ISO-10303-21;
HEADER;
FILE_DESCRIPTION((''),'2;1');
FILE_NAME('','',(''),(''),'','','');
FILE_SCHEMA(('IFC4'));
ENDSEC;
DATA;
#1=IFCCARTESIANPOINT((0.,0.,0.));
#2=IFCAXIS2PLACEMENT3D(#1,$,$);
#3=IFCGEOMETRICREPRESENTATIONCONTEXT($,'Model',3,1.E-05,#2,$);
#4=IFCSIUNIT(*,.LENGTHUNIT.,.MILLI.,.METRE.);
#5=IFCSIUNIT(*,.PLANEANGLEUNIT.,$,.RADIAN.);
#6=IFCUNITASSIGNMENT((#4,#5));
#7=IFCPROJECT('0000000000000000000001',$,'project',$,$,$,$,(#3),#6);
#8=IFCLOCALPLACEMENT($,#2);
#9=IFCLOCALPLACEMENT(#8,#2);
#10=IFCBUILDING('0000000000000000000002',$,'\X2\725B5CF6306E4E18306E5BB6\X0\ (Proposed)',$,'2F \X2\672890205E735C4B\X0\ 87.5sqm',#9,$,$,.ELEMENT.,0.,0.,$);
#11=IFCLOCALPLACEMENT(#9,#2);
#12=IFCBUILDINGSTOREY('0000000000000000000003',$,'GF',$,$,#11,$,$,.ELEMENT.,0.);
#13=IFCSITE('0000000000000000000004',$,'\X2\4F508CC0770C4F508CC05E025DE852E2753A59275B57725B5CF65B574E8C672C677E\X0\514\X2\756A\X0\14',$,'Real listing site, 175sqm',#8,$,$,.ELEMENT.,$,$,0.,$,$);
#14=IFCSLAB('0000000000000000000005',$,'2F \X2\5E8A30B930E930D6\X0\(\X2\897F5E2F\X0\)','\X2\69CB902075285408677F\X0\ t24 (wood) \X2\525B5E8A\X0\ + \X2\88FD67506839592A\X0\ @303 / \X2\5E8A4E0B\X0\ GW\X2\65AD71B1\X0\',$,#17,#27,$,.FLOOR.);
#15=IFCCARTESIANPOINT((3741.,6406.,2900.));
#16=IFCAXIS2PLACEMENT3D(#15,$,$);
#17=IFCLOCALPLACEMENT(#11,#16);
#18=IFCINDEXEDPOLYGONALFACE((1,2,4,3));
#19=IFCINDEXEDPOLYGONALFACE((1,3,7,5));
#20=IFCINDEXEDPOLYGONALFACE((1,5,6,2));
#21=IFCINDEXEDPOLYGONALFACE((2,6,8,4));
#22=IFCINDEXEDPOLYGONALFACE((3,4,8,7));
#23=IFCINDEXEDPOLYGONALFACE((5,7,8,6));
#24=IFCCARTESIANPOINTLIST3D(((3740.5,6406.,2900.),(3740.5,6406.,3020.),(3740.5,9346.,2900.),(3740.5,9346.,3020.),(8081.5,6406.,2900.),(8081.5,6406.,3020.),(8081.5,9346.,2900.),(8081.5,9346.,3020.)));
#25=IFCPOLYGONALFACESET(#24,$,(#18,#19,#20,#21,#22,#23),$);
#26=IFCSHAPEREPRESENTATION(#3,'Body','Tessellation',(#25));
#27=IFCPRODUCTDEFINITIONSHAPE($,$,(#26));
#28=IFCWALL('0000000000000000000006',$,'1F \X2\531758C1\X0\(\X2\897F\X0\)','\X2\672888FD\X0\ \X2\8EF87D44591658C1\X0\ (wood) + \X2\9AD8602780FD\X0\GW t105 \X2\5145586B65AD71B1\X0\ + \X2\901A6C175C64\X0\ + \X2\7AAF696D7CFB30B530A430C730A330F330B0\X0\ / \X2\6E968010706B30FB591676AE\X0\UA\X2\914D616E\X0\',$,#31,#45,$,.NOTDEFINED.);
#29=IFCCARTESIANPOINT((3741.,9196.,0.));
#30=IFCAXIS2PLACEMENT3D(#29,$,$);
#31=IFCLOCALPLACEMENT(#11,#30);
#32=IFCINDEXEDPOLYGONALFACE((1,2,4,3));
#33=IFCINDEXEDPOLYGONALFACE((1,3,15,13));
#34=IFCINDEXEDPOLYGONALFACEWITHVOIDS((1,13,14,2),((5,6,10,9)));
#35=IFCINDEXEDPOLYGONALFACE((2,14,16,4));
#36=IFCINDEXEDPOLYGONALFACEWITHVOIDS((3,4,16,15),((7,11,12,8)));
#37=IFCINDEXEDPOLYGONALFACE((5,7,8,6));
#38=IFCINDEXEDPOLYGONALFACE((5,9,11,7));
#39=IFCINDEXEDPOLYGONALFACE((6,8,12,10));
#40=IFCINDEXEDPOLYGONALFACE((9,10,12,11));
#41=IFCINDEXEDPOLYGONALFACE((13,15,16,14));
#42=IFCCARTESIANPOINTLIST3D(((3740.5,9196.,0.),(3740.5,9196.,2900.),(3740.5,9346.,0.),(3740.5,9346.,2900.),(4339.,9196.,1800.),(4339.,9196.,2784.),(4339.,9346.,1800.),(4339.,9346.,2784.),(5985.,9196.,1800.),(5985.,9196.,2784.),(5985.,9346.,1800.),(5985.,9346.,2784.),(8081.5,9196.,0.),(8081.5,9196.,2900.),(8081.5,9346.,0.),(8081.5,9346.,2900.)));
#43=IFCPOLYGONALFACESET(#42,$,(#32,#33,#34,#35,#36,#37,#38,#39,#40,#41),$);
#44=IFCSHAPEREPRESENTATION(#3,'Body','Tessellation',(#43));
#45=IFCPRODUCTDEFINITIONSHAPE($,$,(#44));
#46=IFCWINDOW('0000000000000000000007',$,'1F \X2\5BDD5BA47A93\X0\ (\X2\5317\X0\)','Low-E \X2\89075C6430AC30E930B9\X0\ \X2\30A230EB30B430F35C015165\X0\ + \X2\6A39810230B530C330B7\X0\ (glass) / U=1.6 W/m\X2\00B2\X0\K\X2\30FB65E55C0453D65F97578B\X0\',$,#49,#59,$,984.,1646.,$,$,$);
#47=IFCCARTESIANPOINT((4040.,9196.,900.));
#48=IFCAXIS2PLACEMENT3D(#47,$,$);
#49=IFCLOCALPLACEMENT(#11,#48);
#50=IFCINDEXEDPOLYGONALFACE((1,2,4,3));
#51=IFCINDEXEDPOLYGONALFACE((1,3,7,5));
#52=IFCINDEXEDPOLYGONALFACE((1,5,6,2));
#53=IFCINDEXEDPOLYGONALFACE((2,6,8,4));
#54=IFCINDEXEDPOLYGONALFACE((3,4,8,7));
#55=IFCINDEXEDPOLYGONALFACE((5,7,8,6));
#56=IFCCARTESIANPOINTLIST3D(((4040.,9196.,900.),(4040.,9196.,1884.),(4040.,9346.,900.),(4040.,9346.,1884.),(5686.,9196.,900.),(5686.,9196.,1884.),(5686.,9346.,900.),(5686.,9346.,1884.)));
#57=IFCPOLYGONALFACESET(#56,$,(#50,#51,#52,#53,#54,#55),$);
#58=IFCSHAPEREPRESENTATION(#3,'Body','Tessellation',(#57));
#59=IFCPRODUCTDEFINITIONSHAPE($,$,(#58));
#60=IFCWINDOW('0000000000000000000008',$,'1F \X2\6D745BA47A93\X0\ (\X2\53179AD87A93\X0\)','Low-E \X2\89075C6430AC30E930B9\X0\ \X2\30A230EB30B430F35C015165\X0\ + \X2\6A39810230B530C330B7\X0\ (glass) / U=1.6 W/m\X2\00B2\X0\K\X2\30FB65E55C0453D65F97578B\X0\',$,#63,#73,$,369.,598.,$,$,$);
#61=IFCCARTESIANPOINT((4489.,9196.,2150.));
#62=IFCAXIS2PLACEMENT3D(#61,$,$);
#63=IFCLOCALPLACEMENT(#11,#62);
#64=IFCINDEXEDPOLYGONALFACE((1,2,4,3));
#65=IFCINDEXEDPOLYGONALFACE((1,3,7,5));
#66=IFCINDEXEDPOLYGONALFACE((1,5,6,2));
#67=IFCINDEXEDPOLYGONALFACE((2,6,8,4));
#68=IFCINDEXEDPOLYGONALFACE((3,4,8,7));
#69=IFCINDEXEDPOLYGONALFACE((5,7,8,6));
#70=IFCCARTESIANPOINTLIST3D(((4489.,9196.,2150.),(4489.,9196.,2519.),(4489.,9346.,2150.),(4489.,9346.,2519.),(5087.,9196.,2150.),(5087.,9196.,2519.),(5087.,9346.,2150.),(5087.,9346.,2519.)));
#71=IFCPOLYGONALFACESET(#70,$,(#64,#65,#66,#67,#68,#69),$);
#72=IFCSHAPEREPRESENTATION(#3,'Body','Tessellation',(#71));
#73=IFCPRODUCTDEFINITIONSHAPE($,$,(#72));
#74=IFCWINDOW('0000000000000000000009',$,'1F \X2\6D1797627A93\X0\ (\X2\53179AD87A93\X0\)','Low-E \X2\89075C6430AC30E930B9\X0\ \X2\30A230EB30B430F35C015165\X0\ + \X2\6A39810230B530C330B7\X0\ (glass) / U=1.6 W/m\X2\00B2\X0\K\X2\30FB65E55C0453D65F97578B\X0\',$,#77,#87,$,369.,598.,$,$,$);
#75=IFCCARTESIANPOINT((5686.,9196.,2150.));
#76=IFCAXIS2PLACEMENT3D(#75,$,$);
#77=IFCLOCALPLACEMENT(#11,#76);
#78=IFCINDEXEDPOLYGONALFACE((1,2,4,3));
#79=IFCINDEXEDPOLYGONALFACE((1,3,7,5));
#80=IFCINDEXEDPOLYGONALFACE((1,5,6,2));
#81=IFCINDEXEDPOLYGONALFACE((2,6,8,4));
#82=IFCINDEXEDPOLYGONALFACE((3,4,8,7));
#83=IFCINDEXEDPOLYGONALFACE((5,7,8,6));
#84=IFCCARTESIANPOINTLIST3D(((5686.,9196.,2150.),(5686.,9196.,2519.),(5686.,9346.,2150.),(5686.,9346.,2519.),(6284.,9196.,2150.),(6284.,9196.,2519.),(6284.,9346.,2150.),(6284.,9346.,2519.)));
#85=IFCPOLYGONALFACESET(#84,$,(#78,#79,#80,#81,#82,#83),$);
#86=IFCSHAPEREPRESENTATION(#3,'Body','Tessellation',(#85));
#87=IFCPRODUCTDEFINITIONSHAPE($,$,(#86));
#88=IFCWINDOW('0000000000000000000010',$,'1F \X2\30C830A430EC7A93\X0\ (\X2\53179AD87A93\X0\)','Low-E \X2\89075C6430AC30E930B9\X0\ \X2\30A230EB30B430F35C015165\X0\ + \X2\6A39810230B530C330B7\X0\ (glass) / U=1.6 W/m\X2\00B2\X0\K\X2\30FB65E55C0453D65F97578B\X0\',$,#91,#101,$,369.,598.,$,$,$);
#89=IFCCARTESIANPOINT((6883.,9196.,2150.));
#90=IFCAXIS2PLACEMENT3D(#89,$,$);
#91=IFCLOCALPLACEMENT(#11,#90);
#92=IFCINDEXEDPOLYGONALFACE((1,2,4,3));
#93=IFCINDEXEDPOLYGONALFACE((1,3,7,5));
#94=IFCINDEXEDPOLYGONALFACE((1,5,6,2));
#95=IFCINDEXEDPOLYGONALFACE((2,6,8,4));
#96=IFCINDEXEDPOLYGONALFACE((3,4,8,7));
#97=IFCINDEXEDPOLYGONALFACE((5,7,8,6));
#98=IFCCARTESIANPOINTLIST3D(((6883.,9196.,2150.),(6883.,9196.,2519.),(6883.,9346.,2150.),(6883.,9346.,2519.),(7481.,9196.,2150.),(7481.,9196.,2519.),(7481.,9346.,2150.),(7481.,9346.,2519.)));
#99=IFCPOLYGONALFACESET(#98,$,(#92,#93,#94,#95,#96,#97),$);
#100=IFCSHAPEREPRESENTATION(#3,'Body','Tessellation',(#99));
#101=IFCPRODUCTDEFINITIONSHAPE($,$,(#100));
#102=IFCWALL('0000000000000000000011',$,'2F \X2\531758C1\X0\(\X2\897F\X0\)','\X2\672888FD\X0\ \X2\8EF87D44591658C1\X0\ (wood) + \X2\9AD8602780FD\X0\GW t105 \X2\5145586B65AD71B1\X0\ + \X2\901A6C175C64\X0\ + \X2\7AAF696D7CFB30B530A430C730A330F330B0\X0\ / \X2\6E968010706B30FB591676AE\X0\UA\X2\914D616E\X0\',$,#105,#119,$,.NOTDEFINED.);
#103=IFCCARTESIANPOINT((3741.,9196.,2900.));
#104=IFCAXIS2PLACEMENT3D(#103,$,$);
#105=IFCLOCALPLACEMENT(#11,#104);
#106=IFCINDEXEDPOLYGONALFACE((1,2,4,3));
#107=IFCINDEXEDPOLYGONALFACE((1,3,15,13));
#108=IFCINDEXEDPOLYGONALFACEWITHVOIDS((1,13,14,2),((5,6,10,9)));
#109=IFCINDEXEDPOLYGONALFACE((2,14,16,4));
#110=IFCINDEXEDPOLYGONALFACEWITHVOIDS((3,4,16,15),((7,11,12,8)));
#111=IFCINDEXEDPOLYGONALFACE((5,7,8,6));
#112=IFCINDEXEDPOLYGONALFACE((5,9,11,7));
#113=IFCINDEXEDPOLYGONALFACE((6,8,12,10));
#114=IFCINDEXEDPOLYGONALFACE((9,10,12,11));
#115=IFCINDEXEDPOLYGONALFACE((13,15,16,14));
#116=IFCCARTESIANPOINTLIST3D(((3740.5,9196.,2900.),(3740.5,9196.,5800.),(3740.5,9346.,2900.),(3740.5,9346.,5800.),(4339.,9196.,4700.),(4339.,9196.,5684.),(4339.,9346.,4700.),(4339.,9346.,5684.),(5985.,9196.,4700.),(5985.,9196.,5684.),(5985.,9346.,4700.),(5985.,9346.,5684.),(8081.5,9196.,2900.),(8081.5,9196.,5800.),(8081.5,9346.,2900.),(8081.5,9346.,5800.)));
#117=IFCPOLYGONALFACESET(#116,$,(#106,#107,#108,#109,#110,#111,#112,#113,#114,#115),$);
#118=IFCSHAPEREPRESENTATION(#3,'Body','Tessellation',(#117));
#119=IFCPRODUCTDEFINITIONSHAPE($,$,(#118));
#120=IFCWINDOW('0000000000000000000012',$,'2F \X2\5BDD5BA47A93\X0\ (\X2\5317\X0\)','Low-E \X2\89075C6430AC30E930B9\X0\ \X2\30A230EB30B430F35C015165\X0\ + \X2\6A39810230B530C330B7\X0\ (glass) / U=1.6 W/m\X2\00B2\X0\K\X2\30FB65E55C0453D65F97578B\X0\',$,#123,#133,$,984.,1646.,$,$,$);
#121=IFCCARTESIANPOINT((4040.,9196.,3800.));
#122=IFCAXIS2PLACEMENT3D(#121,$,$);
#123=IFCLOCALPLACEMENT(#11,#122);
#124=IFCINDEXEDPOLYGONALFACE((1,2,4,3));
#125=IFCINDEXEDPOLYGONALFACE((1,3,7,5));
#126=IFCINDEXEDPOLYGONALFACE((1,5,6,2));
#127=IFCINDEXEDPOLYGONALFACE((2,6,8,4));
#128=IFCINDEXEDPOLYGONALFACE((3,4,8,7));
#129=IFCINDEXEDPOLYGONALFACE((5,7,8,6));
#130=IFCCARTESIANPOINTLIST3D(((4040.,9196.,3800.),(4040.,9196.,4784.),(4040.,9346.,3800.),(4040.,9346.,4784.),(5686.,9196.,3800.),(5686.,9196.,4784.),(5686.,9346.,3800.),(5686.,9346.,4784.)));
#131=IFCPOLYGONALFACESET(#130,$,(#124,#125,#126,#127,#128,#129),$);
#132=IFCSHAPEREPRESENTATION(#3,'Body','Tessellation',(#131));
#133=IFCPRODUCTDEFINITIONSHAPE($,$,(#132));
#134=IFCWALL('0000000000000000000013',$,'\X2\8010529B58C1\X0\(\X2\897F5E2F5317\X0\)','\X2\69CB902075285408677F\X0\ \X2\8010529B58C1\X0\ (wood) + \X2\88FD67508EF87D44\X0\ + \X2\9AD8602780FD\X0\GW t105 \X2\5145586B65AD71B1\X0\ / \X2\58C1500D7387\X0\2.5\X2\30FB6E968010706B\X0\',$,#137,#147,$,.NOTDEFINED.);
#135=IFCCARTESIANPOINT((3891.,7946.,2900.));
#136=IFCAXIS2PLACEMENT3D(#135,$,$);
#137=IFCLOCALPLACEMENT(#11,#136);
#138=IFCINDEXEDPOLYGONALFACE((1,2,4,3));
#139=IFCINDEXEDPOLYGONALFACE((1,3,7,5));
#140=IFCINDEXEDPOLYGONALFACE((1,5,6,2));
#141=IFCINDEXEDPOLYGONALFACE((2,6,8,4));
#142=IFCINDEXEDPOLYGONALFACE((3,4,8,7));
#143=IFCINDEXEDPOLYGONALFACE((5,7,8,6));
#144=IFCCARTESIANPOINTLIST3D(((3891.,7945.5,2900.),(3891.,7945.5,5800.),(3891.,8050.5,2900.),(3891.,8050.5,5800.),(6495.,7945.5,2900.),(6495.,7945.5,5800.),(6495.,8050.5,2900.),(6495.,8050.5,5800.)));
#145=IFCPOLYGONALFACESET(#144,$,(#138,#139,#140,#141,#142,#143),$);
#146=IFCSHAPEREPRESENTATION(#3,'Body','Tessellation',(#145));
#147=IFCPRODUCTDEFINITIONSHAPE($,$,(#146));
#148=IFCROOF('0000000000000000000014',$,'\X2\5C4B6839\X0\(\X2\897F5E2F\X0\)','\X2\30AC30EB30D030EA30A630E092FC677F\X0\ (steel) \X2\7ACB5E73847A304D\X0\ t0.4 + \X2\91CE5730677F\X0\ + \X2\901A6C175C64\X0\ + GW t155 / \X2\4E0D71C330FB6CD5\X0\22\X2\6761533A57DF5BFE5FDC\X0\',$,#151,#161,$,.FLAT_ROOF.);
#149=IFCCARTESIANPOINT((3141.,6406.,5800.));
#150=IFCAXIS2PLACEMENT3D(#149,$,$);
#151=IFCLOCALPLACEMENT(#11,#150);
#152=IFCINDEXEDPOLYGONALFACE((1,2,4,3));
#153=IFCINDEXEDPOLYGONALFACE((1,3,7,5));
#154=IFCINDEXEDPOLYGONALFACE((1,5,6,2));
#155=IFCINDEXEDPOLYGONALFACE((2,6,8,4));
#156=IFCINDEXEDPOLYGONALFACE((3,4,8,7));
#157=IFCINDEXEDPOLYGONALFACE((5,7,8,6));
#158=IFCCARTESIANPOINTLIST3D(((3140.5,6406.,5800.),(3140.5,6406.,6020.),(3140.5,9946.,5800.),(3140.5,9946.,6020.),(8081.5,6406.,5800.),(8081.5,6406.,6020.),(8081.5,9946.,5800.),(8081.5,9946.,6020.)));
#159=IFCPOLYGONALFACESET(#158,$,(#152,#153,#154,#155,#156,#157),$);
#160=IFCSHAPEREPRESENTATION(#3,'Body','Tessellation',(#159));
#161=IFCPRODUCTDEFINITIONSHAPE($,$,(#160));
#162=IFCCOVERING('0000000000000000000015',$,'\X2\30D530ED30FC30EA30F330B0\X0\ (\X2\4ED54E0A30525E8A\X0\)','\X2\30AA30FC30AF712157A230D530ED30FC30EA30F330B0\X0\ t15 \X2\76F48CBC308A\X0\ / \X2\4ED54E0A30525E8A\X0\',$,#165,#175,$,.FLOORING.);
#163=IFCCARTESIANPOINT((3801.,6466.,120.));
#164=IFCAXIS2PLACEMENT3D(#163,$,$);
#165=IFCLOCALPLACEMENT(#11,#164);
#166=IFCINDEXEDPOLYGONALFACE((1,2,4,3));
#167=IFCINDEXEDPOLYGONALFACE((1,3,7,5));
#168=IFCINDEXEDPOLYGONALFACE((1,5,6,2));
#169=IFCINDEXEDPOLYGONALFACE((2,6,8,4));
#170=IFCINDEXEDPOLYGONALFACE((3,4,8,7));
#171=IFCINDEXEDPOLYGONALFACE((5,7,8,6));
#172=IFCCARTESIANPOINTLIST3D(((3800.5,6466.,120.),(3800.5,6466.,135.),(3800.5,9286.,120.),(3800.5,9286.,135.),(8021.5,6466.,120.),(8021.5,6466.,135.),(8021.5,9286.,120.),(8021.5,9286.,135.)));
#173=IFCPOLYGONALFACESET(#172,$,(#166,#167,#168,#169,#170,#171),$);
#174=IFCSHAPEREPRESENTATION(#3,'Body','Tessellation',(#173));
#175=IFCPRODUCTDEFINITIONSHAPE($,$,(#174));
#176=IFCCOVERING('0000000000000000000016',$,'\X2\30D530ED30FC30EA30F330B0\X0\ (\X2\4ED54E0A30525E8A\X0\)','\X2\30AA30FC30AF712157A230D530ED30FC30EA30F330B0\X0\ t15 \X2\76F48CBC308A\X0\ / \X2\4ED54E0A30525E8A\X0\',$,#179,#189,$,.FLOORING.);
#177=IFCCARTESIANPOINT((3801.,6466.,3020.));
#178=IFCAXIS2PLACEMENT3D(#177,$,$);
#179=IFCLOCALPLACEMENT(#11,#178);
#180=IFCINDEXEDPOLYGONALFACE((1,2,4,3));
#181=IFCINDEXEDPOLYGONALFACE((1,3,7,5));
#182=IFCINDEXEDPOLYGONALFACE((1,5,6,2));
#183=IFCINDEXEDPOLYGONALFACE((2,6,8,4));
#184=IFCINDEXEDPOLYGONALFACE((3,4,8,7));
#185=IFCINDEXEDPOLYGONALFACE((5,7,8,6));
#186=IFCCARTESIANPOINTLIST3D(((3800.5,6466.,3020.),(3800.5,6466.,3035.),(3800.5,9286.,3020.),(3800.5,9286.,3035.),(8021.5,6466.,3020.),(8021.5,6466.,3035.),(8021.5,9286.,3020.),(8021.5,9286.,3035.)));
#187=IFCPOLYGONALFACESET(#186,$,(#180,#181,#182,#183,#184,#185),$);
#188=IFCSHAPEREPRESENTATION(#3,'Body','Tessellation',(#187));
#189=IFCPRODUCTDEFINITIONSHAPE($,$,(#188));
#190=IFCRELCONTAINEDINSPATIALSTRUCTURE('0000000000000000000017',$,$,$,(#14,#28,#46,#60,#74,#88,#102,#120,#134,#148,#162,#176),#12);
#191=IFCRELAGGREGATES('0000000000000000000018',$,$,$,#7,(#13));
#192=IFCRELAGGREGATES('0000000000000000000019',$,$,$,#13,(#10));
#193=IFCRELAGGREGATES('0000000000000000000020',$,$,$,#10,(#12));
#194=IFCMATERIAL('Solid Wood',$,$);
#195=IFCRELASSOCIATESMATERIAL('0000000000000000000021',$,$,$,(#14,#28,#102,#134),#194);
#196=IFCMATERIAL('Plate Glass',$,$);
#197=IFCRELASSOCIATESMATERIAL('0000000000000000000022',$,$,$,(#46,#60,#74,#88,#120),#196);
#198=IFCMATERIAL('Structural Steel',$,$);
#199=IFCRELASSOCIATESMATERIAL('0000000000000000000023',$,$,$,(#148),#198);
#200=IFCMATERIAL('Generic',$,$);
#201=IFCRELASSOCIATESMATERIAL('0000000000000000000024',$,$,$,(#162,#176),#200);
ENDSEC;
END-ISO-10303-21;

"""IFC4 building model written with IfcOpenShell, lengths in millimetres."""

from ifc_helpers import new_model, si_unit, frame, frame_2d, origin, place, context, project, spatial, rectangle, extrude, material, element, fill, save


model = new_model("IFC4")

# Units and contexts
model_context = context("Model", 3, precision=1e-05, world=origin())
ifc_project = project(units=[si_unit("LENGTHUNIT", "METRE", prefix="MILLI"), si_unit("PLANEANGLEUNIT", "RADIAN")], contexts=[model_context])

# Site, building, storey
site_placement = place(None, origin())
site = spatial("IfcSite", under=ifc_project, at=site_placement, Name="佐賀県佐賀市巨勢町大字牛島字二本松514番14", ObjectType="Real listing site, 175sqm", CompositionType="ELEMENT", RefElevation=0.0)
building_placement = place(site_placement, origin())
building = spatial("IfcBuilding", under=site, at=building_placement, Name="牛島の丘の家 (Proposed)", ObjectType="2F 木造平屋 87.5sqm", CompositionType="ELEMENT", ElevationOfRefHeight=0.0, ElevationOfTerrain=0.0)
storey_placement = place(building_placement, origin())
storey = spatial("IfcBuildingStorey", under=building, at=storey_placement, Name="GF", CompositionType="ELEMENT", Elevation=0.0)

# Slab
ifc_material_1 = material(Name="Solid Wood")
slab_1_placement = place(storey_placement, frame((3741.0, 6406.0, 2900.0)))
element("IfcSlab", 1, at=slab_1_placement, inside=storey, material=ifc_material_1, Name="2F 床スラブ(西帯)", Description="構造用合板 t24 (wood) 剛床 + 製材根太 @303 / 床下 GW断熱", PredefinedType="FLOOR", context=model_context, shape_type="SweptSolid", body=[
    extrude(rectangle(XDim=4341.0, YDim=2940.0, at=frame_2d((2170.0, 1470.0))), frame((3741.0, 6406.0, 2900.0)), (0.0, 0.0, 1.0), 120.0),
])

# Wall, openings, windows
wall_1_placement = place(storey_placement, frame((3741.0, 9196.0, 0.0)))
wall_1 = element("IfcWall", 2, at=wall_1_placement, inside=storey, material=ifc_material_1, Name="1F 北壁(西)", Description="木製 軸組外壁 (wood) + 高性能GW t105 充填断熱 + 通気層 + 窯業系サイディング / 準耐火・外皮UA配慮", PredefinedType="NOTDEFINED", context=model_context, shape_type="SweptSolid", body=[
    extrude(rectangle(XDim=4341.0, YDim=150.0, at=frame_2d((2170.0, 75.0))), frame((3741.0, 9196.0, 0.0)), (0.0, 0.0, 1.0), 2900.0),
])
opening_1_placement = place(storey_placement, frame((4040.0, 9196.0, 900.0)))
opening_1 = element("IfcOpeningElement", 3, at=opening_1_placement, cuts=wall_1, PredefinedType="NOTDEFINED", context=model_context, shape_type="SweptSolid", body=[
    extrude(rectangle(XDim=1646.0, YDim=150.0, at=frame_2d((823.0, 75.0))), frame((4040.0, 9196.0, 900.0)), (0.0, 0.0, 1.0), 984.0),
])
opening_2_placement = place(storey_placement, frame((4489.0, 9196.0, 2150.0)))
opening_2 = element("IfcOpeningElement", 4, at=opening_2_placement, cuts=wall_1, PredefinedType="NOTDEFINED", context=model_context, shape_type="SweptSolid", body=[
    extrude(rectangle(XDim=598.0, YDim=150.0, at=frame_2d((299.0, 75.0))), frame((4489.0, 9196.0, 2150.0)), (0.0, 0.0, 1.0), 369.0),
])
opening_3_placement = place(storey_placement, frame((5686.0, 9196.0, 2150.0)))
opening_3 = element("IfcOpeningElement", 5, at=opening_3_placement, cuts=wall_1, PredefinedType="NOTDEFINED", context=model_context, shape_type="SweptSolid", body=[
    extrude(rectangle(XDim=598.0, YDim=150.0, at=frame_2d((299.0, 75.0))), frame((5686.0, 9196.0, 2150.0)), (0.0, 0.0, 1.0), 369.0),
])
opening_4_placement = place(storey_placement, frame((6883.0, 9196.0, 2150.0)))
opening_4 = element("IfcOpeningElement", 6, at=opening_4_placement, cuts=wall_1, PredefinedType="NOTDEFINED", context=model_context, shape_type="SweptSolid", body=[
    extrude(rectangle(XDim=598.0, YDim=150.0, at=frame_2d((299.0, 75.0))), frame((6883.0, 9196.0, 2150.0)), (0.0, 0.0, 1.0), 369.0),
])
ifc_material_2 = material(Name="Plate Glass")
window_1_placement = place(storey_placement, frame((4040.0, 9196.0, 900.0)))
window_1 = element("IfcWindow", 7, at=window_1_placement, inside=storey, material=ifc_material_2, Name="1F 寝室窓 (北)", Description="Low-E 複層ガラス アルゴン封入 + 樹脂サッシ (glass) / U=1.6 W/m²K・日射取得型", OverallHeight=984.0, OverallWidth=1646.0, context=model_context, shape_type="SweptSolid", body=[
    extrude(rectangle(XDim=1646.0, YDim=150.0, at=frame_2d((823.0, 75.0))), frame((4040.0, 9196.0, 900.0)), (0.0, 0.0, 1.0), 984.0),
])
fill(opening_1, window_1)
window_2_placement = place(storey_placement, frame((4489.0, 9196.0, 2150.0)))
window_2 = element("IfcWindow", 8, at=window_2_placement, inside=storey, material=ifc_material_2, Name="1F 浴室窓 (北高窓)", Description="Low-E 複層ガラス アルゴン封入 + 樹脂サッシ (glass) / U=1.6 W/m²K・日射取得型", OverallHeight=369.0, OverallWidth=598.0, context=model_context, shape_type="SweptSolid", body=[
    extrude(rectangle(XDim=598.0, YDim=150.0, at=frame_2d((299.0, 75.0))), frame((4489.0, 9196.0, 2150.0)), (0.0, 0.0, 1.0), 369.0),
])
fill(opening_2, window_2)
window_3_placement = place(storey_placement, frame((5686.0, 9196.0, 2150.0)))
window_3 = element("IfcWindow", 9, at=window_3_placement, inside=storey, material=ifc_material_2, Name="1F 洗面窓 (北高窓)", Description="Low-E 複層ガラス アルゴン封入 + 樹脂サッシ (glass) / U=1.6 W/m²K・日射取得型", OverallHeight=369.0, OverallWidth=598.0, context=model_context, shape_type="SweptSolid", body=[
    extrude(rectangle(XDim=598.0, YDim=150.0, at=frame_2d((299.0, 75.0))), frame((5686.0, 9196.0, 2150.0)), (0.0, 0.0, 1.0), 369.0),
])
fill(opening_3, window_3)
window_4_placement = place(storey_placement, frame((6883.0, 9196.0, 2150.0)))
window_4 = element("IfcWindow", 10, at=window_4_placement, inside=storey, material=ifc_material_2, Name="1F トイレ窓 (北高窓)", Description="Low-E 複層ガラス アルゴン封入 + 樹脂サッシ (glass) / U=1.6 W/m²K・日射取得型", OverallHeight=369.0, OverallWidth=598.0, context=model_context, shape_type="SweptSolid", body=[
    extrude(rectangle(XDim=598.0, YDim=150.0, at=frame_2d((299.0, 75.0))), frame((6883.0, 9196.0, 2150.0)), (0.0, 0.0, 1.0), 369.0),
])
fill(opening_4, window_4)

# Wall, opening, window
wall_2_placement = place(storey_placement, frame((3741.0, 9196.0, 2900.0)))
wall_2 = element("IfcWall", 11, at=wall_2_placement, inside=storey, material=ifc_material_1, Name="2F 北壁(西)", Description="木製 軸組外壁 (wood) + 高性能GW t105 充填断熱 + 通気層 + 窯業系サイディング / 準耐火・外皮UA配慮", PredefinedType="NOTDEFINED", context=model_context, shape_type="SweptSolid", body=[
    extrude(rectangle(XDim=4341.0, YDim=150.0, at=frame_2d((2170.0, 75.0))), frame((3741.0, 9196.0, 2900.0)), (0.0, 0.0, 1.0), 2900.0),
])
opening_5_placement = place(storey_placement, frame((4040.0, 9196.0, 3800.0)))
opening_5 = element("IfcOpeningElement", 12, at=opening_5_placement, cuts=wall_2, PredefinedType="NOTDEFINED", context=model_context, shape_type="SweptSolid", body=[
    extrude(rectangle(XDim=1646.0, YDim=150.0, at=frame_2d((823.0, 75.0))), frame((4040.0, 9196.0, 3800.0)), (0.0, 0.0, 1.0), 984.0),
])
window_5_placement = place(storey_placement, frame((4040.0, 9196.0, 3800.0)))
window_5 = element("IfcWindow", 13, at=window_5_placement, inside=storey, material=ifc_material_2, Name="2F 寝室窓 (北)", Description="Low-E 複層ガラス アルゴン封入 + 樹脂サッシ (glass) / U=1.6 W/m²K・日射取得型", OverallHeight=984.0, OverallWidth=1646.0, context=model_context, shape_type="SweptSolid", body=[
    extrude(rectangle(XDim=1646.0, YDim=150.0, at=frame_2d((823.0, 75.0))), frame((4040.0, 9196.0, 3800.0)), (0.0, 0.0, 1.0), 984.0),
])
fill(opening_5, window_5)

# Wall
wall_3_placement = place(storey_placement, frame((3891.0, 7946.0, 2900.0)))
element("IfcWall", 14, at=wall_3_placement, inside=storey, material=ifc_material_1, Name="耐力壁(西帯北)", Description="構造用合板 耐力壁 (wood) + 製材軸組 + 高性能GW t105 充填断熱 / 壁倍率2.5・準耐火", PredefinedType="NOTDEFINED", context=model_context, shape_type="SweptSolid", body=[
    extrude(rectangle(XDim=2604.0, YDim=105.0, at=frame_2d((1302.0, 52.0))), frame((3891.0, 7946.0, 2900.0)), (0.0, 0.0, 1.0), 2900.0),
])

# Roof
ifc_material_3 = material(Name="Structural Steel")
for number, where, name in (
    (15, (3141.0, 6406.0, 5800.0), "屋根(西帯)"),
):
    element("IfcRoof", number, at=place(storey_placement, frame(where)), inside=storey, material=ifc_material_3, Name=name, Description="ガルバリウム鋼板 (steel) 立平葺き t0.4 + 野地板 + 通気層 + GW t155 / 不燃・法22条区域対応", PredefinedType="FLAT_ROOF", context=model_context, shape_type="SweptSolid", body=[
        extrude(rectangle(XDim=4941.0, YDim=3540.0, at=frame_2d((2470.0, 1770.0))), frame((3141.0, 6406.0, 5800.0)), (0.0, 0.0, 1.0), 220.0),
    ])

# Coverings
ifc_material_4 = material(Name="Generic")
covering_1_placement = place(storey_placement, frame((3801.0, 6466.0, 120.0)))
element("IfcCovering", 16, at=covering_1_placement, inside=storey, material=ifc_material_4, Name="フローリング (仕上げ床)", Description="オーク無垢フローリング t15 直貼り / 仕上げ床", PredefinedType="FLOORING", context=model_context, shape_type="SweptSolid", body=[
    extrude(rectangle(XDim=4221.0, YDim=2820.0, at=frame_2d((2110.0, 1410.0))), frame((3801.0, 6466.0, 120.0)), (0.0, 0.0, 1.0), 15.0),
])
covering_2_placement = place(storey_placement, frame((3801.0, 6466.0, 3020.0)))
element("IfcCovering", 17, at=covering_2_placement, inside=storey, material=ifc_material_4, Name="フローリング (仕上げ床)", Description="オーク無垢フローリング t15 直貼り / 仕上げ床", PredefinedType="FLOORING", context=model_context, shape_type="SweptSolid", body=[
    extrude(rectangle(XDim=4221.0, YDim=2820.0, at=frame_2d((2110.0, 1410.0))), frame((3801.0, 6466.0, 3020.0)), (0.0, 0.0, 1.0), 15.0),
])

save(model, "model.ifc")
